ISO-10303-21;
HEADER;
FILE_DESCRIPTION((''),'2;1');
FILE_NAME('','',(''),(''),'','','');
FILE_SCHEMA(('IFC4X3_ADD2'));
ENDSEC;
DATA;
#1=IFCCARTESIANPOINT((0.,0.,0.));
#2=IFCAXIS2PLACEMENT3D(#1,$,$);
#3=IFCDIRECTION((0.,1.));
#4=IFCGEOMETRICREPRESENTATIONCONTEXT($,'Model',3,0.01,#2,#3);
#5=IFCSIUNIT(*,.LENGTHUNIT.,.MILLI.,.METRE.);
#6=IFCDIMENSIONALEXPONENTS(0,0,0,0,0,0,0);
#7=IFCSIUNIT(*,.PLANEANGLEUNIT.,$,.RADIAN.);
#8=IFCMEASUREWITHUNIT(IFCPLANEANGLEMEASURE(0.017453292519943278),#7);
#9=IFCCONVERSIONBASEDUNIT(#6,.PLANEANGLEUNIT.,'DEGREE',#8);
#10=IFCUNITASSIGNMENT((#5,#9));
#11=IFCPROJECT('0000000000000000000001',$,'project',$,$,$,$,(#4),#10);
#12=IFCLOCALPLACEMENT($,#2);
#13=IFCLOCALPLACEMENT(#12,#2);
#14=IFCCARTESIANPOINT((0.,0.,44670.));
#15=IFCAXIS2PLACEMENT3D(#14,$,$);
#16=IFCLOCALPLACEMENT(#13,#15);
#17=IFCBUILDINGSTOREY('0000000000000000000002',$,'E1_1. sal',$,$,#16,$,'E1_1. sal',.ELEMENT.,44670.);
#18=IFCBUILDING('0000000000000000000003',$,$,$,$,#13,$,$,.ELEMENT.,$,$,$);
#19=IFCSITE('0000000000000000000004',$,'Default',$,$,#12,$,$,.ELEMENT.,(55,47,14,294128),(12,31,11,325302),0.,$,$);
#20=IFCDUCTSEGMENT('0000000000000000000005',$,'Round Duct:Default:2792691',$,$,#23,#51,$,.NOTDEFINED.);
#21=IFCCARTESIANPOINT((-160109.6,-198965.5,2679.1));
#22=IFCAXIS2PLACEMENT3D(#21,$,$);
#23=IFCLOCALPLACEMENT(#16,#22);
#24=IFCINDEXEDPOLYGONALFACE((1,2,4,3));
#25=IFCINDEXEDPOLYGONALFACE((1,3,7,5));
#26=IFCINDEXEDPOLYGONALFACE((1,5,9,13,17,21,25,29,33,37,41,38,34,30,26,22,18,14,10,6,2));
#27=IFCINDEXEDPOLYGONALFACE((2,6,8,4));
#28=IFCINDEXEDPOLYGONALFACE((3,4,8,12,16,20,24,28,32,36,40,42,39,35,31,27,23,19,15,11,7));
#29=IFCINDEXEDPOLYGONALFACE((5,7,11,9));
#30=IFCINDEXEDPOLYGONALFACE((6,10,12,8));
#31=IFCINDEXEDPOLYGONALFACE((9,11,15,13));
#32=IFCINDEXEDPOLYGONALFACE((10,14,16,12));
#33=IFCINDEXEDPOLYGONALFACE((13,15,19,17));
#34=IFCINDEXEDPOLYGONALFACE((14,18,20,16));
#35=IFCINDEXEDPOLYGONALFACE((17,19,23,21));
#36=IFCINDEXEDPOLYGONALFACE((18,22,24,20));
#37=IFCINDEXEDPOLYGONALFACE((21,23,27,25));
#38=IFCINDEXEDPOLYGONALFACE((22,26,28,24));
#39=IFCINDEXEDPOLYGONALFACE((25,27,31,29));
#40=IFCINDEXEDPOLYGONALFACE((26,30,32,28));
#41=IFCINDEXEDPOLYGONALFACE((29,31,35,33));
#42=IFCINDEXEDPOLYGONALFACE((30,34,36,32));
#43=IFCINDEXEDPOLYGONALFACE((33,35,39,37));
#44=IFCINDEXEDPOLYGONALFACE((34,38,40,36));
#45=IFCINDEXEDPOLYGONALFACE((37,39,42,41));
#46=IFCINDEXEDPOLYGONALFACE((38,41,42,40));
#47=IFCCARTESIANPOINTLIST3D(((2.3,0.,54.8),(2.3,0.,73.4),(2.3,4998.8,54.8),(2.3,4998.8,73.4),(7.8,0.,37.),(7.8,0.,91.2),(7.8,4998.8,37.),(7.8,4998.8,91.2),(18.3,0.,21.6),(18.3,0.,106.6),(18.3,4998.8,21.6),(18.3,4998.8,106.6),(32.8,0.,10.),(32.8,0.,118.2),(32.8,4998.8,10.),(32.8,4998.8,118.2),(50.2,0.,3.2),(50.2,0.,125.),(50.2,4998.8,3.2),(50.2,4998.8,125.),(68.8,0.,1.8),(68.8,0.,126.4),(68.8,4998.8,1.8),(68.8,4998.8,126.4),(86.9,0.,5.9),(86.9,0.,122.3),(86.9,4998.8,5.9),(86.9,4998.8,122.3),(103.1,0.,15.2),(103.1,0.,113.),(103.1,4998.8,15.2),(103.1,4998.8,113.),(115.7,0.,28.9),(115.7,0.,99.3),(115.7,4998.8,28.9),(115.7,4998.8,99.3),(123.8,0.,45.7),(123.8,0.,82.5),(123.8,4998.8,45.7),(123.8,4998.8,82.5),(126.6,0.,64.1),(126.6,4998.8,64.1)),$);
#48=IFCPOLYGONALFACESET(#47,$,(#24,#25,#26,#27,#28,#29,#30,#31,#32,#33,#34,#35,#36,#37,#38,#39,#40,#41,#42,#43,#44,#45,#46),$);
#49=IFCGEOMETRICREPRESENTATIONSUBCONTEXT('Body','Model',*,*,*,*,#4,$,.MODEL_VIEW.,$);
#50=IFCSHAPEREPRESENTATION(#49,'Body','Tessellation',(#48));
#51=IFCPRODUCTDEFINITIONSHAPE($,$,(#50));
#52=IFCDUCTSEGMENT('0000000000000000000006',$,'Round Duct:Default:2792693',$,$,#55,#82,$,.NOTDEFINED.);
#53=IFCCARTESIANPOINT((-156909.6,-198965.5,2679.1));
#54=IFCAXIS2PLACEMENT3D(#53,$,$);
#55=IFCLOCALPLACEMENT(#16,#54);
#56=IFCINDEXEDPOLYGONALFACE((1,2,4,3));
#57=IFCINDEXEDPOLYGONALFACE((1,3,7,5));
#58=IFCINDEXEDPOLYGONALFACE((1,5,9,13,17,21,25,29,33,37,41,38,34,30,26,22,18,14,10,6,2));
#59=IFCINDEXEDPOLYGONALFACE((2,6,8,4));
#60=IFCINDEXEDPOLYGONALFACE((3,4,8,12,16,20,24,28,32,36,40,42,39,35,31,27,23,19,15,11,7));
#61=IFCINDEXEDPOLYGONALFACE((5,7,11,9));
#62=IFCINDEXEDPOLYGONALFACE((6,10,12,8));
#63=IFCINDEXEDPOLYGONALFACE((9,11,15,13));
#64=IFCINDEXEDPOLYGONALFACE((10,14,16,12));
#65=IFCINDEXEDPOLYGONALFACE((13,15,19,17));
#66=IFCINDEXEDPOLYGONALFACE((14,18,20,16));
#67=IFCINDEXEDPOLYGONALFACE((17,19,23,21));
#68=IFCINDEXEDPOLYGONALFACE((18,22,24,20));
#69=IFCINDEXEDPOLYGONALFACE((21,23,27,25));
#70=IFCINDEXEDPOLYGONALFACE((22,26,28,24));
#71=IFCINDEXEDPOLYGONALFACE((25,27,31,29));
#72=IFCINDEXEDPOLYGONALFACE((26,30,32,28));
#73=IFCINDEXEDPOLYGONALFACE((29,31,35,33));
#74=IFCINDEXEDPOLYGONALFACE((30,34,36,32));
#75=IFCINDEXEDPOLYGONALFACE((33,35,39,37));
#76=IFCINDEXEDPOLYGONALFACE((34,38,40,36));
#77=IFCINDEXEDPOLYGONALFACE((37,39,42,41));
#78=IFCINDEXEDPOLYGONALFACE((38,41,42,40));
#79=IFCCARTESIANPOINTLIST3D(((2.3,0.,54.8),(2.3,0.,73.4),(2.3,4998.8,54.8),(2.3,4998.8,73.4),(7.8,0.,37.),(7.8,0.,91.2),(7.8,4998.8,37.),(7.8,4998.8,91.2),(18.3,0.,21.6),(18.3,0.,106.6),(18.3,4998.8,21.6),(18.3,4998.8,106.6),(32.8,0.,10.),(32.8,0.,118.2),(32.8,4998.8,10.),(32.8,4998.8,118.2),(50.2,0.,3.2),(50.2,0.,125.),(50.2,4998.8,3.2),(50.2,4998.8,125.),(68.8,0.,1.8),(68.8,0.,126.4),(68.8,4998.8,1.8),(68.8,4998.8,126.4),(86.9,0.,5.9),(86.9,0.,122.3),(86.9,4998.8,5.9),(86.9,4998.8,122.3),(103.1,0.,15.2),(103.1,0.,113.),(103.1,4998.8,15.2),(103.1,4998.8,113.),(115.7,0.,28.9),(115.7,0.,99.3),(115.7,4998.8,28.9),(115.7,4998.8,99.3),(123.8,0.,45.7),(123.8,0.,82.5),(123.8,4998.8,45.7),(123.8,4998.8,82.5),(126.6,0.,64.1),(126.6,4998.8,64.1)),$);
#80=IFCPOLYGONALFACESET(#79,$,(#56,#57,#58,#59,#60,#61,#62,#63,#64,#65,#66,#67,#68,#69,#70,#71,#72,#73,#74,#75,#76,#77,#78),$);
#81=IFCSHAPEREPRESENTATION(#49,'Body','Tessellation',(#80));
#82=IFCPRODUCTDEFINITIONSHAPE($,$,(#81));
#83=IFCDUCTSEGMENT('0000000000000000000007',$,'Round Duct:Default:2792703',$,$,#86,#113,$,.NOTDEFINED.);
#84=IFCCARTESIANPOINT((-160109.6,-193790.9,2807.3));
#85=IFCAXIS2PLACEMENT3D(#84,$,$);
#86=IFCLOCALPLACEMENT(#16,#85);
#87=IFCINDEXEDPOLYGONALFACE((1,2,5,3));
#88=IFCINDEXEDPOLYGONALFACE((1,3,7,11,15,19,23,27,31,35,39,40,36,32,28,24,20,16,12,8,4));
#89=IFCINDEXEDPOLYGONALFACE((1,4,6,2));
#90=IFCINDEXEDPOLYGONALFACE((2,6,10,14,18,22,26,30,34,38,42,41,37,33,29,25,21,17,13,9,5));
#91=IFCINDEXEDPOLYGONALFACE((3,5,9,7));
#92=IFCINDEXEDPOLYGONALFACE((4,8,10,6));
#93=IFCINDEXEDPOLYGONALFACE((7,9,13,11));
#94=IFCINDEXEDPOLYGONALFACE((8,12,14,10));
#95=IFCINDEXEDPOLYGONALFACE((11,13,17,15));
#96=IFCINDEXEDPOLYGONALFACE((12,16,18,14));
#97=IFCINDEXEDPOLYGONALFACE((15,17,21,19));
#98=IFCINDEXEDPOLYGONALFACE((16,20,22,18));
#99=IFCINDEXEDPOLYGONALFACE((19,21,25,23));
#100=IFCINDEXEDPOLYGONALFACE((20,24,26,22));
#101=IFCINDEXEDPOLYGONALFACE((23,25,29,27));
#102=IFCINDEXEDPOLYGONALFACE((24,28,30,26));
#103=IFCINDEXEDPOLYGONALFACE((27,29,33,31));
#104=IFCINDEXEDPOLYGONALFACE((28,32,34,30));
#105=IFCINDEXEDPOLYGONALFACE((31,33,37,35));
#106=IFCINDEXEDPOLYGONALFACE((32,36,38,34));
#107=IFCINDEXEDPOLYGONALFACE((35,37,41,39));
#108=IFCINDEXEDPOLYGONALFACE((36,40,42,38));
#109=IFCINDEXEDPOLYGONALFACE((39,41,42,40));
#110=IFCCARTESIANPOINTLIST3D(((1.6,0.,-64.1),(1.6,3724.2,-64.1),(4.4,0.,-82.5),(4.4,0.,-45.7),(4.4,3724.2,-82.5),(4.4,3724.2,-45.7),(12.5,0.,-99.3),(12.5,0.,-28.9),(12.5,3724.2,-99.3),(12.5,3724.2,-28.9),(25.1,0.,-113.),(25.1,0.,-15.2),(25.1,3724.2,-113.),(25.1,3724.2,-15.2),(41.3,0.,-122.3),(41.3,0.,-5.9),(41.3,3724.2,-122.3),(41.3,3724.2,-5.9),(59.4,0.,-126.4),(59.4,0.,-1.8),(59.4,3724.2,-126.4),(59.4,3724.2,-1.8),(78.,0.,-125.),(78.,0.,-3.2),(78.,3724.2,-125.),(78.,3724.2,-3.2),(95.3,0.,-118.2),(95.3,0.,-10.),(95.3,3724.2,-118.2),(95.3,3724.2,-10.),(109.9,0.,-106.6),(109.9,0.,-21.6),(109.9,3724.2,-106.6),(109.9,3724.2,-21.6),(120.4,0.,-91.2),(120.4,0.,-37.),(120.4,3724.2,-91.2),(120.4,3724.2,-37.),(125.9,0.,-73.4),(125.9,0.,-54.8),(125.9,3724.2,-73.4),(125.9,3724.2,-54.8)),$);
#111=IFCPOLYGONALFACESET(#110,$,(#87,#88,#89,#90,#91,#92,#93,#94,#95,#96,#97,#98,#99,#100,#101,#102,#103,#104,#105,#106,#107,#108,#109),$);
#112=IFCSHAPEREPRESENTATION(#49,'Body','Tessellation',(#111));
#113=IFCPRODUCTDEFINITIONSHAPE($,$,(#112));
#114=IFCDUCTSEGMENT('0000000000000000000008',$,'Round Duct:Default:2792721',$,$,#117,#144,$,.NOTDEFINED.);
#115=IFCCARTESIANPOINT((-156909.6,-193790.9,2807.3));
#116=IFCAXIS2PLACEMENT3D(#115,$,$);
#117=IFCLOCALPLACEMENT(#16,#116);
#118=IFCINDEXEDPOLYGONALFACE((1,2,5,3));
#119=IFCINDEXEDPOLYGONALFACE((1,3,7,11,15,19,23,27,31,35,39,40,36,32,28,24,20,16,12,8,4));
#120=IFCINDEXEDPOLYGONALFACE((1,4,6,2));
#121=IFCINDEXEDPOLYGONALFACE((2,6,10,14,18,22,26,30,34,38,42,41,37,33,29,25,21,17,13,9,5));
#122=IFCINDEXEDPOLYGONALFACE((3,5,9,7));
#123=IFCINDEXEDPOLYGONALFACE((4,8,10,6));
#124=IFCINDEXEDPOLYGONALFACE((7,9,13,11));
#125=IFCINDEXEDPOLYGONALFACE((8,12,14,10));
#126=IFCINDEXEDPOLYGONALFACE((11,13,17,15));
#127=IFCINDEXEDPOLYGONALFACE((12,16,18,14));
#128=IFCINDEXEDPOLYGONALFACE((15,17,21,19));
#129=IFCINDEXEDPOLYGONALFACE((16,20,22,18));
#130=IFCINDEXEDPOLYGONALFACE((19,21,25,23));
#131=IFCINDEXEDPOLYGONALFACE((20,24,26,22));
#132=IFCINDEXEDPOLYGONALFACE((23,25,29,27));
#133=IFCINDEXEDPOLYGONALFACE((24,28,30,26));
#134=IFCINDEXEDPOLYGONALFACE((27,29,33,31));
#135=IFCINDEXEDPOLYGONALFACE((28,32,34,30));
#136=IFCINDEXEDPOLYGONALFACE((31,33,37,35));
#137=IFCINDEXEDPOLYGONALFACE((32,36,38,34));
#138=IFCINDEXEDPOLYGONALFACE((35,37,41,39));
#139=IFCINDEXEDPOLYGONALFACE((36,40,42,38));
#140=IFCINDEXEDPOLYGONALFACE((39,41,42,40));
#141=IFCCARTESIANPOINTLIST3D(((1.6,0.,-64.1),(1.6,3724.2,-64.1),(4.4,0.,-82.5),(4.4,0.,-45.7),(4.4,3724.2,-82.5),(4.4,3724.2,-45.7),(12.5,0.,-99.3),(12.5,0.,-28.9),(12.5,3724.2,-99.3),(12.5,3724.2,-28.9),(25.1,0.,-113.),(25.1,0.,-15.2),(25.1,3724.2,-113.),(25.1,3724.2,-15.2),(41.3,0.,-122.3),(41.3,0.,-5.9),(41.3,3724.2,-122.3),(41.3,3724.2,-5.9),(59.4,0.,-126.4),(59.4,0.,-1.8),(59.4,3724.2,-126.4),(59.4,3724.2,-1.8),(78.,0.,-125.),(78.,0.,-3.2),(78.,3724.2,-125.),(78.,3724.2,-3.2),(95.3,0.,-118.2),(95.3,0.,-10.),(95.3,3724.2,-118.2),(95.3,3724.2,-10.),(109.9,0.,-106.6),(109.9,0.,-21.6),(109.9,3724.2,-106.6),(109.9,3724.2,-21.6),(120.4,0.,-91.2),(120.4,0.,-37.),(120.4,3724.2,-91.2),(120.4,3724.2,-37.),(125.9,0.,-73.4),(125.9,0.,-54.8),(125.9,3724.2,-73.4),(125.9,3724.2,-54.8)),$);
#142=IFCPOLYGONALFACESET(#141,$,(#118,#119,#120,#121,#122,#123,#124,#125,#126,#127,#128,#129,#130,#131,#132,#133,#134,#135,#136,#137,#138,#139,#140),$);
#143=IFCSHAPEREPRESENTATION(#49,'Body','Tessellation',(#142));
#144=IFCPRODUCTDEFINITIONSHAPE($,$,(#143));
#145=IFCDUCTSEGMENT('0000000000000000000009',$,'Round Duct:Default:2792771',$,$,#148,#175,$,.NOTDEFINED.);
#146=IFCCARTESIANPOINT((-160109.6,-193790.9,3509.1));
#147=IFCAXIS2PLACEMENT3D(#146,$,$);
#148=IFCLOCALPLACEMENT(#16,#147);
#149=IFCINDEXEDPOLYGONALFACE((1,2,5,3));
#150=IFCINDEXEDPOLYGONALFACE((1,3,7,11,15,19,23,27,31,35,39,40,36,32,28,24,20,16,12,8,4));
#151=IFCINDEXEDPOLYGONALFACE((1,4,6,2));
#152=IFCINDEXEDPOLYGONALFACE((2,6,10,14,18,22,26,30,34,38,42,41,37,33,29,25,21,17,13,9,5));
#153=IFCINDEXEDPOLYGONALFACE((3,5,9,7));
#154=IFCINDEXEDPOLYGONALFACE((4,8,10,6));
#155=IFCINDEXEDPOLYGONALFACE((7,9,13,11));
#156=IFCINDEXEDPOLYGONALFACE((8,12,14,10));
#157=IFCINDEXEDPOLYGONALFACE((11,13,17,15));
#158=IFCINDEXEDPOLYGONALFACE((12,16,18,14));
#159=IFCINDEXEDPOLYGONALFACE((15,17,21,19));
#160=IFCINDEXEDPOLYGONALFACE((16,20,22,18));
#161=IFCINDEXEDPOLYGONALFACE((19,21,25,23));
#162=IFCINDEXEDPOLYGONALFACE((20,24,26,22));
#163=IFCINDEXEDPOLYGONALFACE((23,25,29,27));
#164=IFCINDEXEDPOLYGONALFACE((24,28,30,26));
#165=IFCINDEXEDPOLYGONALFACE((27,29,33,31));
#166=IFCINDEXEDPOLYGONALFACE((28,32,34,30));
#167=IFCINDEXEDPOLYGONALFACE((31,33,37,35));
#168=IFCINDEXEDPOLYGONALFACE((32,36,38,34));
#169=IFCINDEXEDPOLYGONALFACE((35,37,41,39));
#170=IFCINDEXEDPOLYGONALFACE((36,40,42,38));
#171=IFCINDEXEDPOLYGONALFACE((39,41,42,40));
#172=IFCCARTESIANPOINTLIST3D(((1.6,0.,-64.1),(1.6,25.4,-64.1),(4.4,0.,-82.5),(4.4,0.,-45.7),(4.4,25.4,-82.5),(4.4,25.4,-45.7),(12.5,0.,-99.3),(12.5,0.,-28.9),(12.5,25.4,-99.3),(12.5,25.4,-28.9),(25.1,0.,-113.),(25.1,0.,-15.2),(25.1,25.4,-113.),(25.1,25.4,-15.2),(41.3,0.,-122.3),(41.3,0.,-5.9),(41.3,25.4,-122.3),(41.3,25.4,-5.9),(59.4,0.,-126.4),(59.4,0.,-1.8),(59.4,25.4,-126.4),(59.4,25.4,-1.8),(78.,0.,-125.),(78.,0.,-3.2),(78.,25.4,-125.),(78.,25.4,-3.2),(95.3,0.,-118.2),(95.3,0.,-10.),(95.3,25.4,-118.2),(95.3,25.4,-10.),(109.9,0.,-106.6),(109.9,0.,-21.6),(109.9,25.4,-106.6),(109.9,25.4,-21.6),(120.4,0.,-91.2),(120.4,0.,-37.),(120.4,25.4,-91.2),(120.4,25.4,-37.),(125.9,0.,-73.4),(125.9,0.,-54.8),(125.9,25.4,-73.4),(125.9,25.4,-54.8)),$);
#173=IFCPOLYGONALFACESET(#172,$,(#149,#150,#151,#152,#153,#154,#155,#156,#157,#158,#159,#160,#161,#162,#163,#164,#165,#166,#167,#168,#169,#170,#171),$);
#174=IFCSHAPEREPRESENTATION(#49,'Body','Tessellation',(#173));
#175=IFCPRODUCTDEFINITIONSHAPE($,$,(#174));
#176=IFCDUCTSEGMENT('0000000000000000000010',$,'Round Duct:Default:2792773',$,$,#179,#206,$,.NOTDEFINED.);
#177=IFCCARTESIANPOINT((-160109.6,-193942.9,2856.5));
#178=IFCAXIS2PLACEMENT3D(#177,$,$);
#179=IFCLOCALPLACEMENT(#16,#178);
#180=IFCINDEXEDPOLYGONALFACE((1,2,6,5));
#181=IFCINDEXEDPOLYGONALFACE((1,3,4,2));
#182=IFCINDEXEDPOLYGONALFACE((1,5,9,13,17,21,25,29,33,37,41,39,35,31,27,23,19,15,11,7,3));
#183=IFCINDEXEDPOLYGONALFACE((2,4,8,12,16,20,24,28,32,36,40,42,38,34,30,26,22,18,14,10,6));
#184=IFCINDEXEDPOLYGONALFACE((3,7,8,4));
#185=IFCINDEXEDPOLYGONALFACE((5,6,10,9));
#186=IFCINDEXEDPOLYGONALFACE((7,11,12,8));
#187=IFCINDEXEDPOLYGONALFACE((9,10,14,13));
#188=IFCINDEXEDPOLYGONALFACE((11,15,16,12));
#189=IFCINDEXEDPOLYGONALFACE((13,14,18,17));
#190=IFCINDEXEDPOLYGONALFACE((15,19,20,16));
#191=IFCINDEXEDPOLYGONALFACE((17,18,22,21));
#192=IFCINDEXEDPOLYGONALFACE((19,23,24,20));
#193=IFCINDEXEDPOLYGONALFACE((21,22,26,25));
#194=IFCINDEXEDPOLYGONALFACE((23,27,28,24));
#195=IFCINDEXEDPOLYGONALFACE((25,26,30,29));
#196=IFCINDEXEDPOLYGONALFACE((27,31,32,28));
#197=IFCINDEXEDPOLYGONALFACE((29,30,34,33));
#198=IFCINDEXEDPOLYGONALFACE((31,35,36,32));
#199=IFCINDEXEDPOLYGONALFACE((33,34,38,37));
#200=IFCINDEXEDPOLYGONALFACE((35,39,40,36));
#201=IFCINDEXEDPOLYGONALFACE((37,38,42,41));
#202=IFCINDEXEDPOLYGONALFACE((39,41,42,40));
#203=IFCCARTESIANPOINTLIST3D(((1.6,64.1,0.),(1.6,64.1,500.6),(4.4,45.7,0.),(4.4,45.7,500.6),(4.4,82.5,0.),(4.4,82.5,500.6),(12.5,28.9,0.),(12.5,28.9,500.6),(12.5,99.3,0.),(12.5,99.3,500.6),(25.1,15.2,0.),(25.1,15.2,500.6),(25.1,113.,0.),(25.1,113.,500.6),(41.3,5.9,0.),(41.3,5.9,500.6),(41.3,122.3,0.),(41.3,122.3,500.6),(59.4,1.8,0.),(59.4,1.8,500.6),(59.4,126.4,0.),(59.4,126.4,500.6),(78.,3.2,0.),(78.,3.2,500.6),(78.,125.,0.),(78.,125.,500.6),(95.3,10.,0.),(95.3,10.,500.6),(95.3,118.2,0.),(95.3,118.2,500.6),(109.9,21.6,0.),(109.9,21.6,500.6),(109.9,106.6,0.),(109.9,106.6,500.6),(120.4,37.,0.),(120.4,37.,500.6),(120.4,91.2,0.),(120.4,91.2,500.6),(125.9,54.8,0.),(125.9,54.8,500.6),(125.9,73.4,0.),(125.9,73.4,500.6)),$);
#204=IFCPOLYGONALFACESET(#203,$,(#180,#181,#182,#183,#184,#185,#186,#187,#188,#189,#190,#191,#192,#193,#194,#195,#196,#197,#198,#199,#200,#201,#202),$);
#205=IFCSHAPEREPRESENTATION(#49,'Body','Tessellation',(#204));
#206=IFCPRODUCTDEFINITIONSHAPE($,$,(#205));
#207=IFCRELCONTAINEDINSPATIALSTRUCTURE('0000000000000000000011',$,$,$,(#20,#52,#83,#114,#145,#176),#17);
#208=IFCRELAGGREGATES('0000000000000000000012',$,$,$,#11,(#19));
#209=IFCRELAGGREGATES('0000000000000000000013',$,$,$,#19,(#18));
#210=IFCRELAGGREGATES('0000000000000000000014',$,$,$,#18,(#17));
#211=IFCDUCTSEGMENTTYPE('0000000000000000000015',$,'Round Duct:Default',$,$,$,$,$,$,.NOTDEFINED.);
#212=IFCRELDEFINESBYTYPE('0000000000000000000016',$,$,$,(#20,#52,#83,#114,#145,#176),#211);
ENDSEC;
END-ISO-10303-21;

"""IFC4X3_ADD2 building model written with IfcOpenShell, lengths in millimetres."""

from ifc_helpers import new_model, entity, si_unit, converted_unit, direction, frame, frame_2d, origin, origin_2d_with_axis, place, context, subcontext, project, spatial, circle, extrude, type_object, element, save


model = new_model("IFC4X3_ADD2")

# Units and contexts
model_context = context("Model", 3, precision=0.01, world=origin(), true_north=direction((0.0, 1.0)))
body_context = subcontext(model_context, "Body", "Model", "MODEL_VIEW")
ifc_project = project(units=[si_unit("LENGTHUNIT", "METRE", prefix="MILLI"), converted_unit("PLANEANGLEUNIT", "DEGREE", entity("IfcPlaneAngleMeasure", 0.017453292519943278), si_unit("PLANEANGLEUNIT", "RADIAN"), dimensions=[0, 0, 0, 0, 0, 0, 0])], contexts=[model_context])

# Site, building, storey
site_placement = place(None, origin())
site = spatial("IfcSite", under=ifc_project, at=site_placement, Name="Default", CompositionType="ELEMENT", RefLatitude=(55, 47, 14, 294128), RefLongitude=(12, 31, 11, 325302), RefElevation=0.0)
building_placement = place(site_placement, origin())
building = spatial("IfcBuilding", under=site, at=building_placement, CompositionType="ELEMENT")
storey_placement = place(building_placement, frame((0.0, 0.0, 44670.0)))
storey = spatial("IfcBuildingStorey", under=building, at=storey_placement, Name="E1_1. sal", LongName="E1_1. sal", CompositionType="ELEMENT", Elevation=44670.0)

# Duct segments
duct_segment_type = type_object("IfcDuctSegmentType", Name="Round Duct:Default", PredefinedType="NOTDEFINED")
for number, where, name in (
    (1, (-160109.6, -198965.5, 2679.1), "Round Duct:Default:2792691"),
    (2, (-156909.6, -198965.5, 2679.1), "Round Duct:Default:2792693"),
):
    element("IfcDuctSegment", number, at=place(storey_placement, frame(where)), inside=storey, type_object=duct_segment_type, Name=name, PredefinedType="NOTDEFINED", context=body_context, shape_type="SweptSolid", body=[
        extrude(circle(Radius=62.5, at=origin_2d_with_axis()), frame((64.1, 0.0, 64.1), z_axis=(0.0, 1.0, 0.0), x_axis=(1.0, 0.0, 0.0)), (0.0, 0.0, 1.0), 4998.8),
    ])
for number, where, name in (
    (3, (-160109.6, -193790.9, 2807.3), "Round Duct:Default:2792703"),
    (4, (-156909.6, -193790.9, 2807.3), "Round Duct:Default:2792721"),
):
    element("IfcDuctSegment", number, at=place(storey_placement, frame(where)), inside=storey, type_object=duct_segment_type, Name=name, PredefinedType="NOTDEFINED", context=body_context, shape_type="SweptSolid", body=[
        extrude(circle(Radius=62.5, at=frame_2d((0.0, 0.0), x_axis=(1.0, 0.0))), frame((64.1, 0.0, -64.1), z_axis=(0.0, 1.0, 0.0), x_axis=(-1.0, 0.0, 0.0)), (0.0, 0.0, 1.0), 3724.2),
    ])
duct_segment_1_placement = place(storey_placement, frame((-160109.6, -193790.9, 3509.1)))
element("IfcDuctSegment", 5, at=duct_segment_1_placement, inside=storey, type_object=duct_segment_type, Name="Round Duct:Default:2792771", PredefinedType="NOTDEFINED", context=body_context, shape_type="SweptSolid", body=[
    extrude(circle(Radius=62.5, at=origin_2d_with_axis()), frame((64.1, 0.0, -64.1), z_axis=(0.0, 1.0, 0.0), x_axis=(-1.0, 0.0, 0.0)), (0.0, 0.0, 1.0), 25.4),
])
duct_segment_2_placement = place(storey_placement, frame((-160109.6, -193942.9, 2856.5)))
element("IfcDuctSegment", 6, at=duct_segment_2_placement, inside=storey, type_object=duct_segment_type, Name="Round Duct:Default:2792773", PredefinedType="NOTDEFINED", context=body_context, shape_type="SweptSolid", body=[
    extrude(circle(Radius=62.5, at=origin_2d_with_axis()), frame((64.1, 64.1, 0.0), z_axis=(0.0, 0.0, 1.0), x_axis=(-1.0, 0.0, 0.0)), (0.0, 0.0, 1.0), 500.6),
])

save(model, "model.ifc")
